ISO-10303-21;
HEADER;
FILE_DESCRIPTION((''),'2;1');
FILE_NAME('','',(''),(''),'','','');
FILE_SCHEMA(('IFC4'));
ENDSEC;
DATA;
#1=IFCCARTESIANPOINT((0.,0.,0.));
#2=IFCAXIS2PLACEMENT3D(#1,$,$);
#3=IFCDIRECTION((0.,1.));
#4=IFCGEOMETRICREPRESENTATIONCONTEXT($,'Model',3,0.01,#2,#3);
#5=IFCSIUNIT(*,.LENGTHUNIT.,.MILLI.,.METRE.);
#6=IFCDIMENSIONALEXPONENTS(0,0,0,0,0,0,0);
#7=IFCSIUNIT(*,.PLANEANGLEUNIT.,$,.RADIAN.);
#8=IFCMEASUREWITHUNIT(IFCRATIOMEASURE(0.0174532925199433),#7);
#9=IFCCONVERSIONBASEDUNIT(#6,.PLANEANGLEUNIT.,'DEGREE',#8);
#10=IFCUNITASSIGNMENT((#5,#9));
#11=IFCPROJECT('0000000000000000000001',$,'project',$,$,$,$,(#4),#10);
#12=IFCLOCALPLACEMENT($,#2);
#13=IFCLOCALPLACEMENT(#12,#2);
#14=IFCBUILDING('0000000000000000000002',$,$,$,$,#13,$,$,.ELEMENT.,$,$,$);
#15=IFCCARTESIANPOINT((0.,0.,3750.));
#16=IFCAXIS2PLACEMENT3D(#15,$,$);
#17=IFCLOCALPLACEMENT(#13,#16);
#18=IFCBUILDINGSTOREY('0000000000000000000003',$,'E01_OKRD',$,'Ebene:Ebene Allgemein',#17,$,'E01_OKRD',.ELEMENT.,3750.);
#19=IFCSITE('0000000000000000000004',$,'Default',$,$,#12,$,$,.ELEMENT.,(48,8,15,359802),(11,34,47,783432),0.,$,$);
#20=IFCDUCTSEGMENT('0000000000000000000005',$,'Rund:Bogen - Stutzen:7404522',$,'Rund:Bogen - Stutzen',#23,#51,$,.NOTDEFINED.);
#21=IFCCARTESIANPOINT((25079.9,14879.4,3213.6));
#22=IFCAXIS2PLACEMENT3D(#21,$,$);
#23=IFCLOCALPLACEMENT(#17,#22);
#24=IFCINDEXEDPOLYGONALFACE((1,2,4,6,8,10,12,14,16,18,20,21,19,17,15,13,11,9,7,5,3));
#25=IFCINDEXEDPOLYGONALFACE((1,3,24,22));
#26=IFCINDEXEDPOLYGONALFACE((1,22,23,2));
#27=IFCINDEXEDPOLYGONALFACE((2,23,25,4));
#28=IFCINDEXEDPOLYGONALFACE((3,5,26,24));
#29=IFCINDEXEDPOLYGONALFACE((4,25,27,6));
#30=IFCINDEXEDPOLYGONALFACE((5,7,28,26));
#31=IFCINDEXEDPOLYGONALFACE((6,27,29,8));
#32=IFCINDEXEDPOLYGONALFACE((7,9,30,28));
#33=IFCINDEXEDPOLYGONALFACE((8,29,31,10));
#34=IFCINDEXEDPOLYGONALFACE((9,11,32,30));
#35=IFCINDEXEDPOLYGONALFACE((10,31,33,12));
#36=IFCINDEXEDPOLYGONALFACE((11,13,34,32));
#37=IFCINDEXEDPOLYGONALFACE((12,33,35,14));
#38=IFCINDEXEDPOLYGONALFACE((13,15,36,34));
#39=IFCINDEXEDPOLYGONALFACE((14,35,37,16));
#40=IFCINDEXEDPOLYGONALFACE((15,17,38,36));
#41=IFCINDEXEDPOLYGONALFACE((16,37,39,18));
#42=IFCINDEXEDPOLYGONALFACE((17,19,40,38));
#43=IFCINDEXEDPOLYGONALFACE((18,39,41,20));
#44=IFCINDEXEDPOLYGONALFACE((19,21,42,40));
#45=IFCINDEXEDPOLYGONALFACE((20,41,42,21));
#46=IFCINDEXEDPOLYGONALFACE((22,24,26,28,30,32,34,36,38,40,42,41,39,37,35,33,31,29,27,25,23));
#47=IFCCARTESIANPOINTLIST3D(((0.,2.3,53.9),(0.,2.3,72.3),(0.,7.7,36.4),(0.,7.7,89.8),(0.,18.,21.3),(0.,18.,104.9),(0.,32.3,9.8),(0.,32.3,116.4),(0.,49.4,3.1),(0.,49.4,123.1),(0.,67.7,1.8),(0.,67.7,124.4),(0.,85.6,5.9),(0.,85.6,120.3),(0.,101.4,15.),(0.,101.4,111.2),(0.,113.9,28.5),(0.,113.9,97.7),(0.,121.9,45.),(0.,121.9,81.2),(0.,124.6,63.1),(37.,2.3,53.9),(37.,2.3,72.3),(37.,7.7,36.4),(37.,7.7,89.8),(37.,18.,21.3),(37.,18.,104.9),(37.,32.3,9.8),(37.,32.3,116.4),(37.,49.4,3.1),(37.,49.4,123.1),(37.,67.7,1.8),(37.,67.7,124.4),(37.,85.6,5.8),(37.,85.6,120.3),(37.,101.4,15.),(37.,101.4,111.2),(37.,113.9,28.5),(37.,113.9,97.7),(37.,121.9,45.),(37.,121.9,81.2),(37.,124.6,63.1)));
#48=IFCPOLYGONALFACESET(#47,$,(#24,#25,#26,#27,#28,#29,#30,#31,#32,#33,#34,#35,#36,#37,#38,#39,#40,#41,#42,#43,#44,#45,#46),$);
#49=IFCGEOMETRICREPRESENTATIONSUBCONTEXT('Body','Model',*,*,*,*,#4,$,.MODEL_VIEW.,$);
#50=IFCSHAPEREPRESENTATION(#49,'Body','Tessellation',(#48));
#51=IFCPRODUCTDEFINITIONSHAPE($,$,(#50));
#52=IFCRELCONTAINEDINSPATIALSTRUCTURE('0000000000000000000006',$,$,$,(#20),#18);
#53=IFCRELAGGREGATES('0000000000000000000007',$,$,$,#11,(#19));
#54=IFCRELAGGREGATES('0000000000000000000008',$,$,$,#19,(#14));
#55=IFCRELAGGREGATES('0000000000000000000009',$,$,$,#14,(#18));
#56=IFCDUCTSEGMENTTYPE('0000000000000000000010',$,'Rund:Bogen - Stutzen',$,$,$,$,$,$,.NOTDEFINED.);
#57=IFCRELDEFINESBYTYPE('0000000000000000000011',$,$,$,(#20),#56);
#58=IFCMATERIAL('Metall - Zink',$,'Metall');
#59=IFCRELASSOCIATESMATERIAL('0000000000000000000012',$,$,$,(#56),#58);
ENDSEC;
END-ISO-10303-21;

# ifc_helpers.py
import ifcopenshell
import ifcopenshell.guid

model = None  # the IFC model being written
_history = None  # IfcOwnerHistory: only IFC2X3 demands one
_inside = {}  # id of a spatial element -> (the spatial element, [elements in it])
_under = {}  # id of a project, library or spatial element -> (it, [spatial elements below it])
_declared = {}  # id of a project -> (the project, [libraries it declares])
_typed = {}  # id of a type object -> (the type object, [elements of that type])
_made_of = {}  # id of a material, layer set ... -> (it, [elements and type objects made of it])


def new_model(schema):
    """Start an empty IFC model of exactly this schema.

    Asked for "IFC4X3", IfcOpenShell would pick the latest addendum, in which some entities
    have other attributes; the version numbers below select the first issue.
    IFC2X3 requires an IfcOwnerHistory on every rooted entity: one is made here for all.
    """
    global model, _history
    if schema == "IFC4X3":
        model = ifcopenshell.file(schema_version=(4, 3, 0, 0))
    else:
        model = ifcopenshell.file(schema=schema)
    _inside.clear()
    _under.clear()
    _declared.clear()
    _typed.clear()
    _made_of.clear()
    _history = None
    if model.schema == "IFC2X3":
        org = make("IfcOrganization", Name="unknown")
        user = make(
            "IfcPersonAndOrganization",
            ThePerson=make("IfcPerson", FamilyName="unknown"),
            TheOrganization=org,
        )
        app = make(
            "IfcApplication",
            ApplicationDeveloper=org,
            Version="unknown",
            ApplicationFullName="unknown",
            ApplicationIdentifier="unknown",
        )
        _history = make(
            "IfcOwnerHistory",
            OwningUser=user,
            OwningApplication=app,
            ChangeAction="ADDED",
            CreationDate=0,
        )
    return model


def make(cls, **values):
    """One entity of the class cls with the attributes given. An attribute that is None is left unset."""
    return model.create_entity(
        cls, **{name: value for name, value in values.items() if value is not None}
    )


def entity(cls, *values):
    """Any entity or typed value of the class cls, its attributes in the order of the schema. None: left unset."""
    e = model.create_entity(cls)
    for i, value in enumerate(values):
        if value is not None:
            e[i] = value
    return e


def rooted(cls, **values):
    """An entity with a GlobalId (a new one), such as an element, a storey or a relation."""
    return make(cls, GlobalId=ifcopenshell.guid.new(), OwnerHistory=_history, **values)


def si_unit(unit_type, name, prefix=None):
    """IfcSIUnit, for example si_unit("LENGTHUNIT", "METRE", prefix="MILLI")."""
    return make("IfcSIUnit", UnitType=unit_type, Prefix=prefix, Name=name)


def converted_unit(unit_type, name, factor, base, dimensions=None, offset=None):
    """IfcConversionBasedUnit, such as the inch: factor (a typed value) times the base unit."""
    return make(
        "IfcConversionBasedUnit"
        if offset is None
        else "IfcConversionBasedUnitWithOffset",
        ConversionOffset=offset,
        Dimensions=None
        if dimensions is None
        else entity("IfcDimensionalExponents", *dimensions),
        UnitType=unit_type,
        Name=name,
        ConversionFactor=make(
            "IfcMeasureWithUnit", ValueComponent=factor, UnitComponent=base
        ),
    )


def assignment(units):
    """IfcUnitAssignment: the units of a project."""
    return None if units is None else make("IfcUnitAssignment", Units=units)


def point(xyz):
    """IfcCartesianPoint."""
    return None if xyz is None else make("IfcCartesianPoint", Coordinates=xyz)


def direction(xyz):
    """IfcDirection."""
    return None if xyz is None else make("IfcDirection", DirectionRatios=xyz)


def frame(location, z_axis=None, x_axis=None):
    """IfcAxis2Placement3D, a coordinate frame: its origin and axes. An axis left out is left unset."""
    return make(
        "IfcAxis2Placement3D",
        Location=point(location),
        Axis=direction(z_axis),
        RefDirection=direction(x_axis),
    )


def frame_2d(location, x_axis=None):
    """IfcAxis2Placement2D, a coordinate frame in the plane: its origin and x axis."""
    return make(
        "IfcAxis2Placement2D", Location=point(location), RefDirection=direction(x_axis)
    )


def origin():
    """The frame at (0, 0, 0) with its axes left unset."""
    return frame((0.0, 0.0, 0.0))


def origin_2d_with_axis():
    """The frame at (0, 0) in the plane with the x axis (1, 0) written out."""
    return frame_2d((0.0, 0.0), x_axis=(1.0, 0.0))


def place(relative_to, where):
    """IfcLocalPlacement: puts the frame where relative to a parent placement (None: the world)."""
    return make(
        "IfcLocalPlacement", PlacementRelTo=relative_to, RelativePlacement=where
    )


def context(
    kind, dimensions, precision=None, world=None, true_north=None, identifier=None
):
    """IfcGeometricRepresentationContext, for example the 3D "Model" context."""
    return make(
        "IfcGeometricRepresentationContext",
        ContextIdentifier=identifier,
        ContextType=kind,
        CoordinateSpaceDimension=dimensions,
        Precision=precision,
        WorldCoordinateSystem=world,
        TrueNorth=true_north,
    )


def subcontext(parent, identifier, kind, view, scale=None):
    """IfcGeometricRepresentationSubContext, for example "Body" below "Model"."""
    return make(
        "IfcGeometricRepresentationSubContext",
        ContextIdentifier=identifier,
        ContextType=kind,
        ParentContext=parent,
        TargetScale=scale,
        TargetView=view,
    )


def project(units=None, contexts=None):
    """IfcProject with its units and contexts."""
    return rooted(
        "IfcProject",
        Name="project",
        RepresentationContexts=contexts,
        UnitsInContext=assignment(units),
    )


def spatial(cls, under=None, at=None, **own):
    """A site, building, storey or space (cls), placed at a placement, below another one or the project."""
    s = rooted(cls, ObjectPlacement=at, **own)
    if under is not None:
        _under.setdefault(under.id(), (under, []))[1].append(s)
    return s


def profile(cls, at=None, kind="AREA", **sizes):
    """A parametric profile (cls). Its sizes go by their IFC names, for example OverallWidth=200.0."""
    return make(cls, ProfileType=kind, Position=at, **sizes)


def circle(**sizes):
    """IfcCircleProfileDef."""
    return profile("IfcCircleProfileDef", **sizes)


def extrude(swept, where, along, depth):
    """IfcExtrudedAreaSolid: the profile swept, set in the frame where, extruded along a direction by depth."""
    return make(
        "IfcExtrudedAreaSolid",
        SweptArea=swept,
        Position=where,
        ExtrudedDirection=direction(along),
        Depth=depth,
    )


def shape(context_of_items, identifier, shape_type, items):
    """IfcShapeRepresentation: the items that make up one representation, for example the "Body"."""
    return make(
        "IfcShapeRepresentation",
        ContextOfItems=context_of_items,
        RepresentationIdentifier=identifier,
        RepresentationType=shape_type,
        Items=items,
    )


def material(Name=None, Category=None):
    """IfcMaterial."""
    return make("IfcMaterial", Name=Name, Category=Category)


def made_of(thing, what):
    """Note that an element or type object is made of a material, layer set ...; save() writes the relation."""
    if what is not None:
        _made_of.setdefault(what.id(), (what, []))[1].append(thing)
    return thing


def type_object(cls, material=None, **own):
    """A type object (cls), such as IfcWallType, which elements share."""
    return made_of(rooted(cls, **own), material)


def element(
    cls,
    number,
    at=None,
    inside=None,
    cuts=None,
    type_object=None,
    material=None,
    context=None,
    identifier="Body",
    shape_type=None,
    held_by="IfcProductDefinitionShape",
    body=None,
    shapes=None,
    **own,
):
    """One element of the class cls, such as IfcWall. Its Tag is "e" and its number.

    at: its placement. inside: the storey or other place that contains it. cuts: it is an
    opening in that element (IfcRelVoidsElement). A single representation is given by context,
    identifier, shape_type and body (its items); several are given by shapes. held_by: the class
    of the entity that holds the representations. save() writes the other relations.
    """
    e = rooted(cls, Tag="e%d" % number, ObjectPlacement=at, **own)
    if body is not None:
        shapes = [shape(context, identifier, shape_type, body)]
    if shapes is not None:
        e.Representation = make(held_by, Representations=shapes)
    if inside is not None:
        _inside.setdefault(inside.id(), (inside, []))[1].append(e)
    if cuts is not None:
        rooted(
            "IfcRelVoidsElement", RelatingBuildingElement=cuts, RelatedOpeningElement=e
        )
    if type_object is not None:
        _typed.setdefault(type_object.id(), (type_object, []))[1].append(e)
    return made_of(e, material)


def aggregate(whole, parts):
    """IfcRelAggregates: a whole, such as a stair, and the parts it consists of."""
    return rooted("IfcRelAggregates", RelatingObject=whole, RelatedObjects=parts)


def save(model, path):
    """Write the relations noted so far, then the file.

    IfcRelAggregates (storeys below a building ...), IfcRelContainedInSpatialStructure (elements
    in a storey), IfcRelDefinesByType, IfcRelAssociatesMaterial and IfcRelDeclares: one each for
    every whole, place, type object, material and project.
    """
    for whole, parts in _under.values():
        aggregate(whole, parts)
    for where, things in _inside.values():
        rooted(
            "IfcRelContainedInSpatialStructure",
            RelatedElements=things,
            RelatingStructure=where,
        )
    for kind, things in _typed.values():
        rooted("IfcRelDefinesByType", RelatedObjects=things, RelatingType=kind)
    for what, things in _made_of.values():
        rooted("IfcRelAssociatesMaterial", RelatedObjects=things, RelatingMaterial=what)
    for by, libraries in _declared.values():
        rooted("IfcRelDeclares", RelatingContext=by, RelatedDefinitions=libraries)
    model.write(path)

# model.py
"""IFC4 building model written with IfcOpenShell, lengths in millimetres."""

from ifc_helpers import new_model, entity, si_unit, converted_unit, direction, frame, origin, origin_2d_with_axis, place, context, subcontext, project, spatial, circle, extrude, material, type_object, element, save


model = new_model("IFC4")

# Units and contexts
model_context = context("Model", 3, precision=0.01, world=origin(), true_north=direction((0.0, 1.0)))
body_context = subcontext(model_context, "Body", "Model", "MODEL_VIEW")
ifc_project = project(units=[si_unit("LENGTHUNIT", "METRE", prefix="MILLI"), converted_unit("PLANEANGLEUNIT", "DEGREE", entity("IfcRatioMeasure", 0.0174532925199433), si_unit("PLANEANGLEUNIT", "RADIAN"), dimensions=[0, 0, 0, 0, 0, 0, 0])], contexts=[model_context])

# Site, building, storey
site_placement = place(None, origin())
site = spatial("IfcSite", under=ifc_project, at=site_placement, Name="Default", CompositionType="ELEMENT", RefLatitude=(48, 8, 15, 359802), RefLongitude=(11, 34, 47, 783432), RefElevation=0.0)
building_placement = place(site_placement, origin())
building = spatial("IfcBuilding", under=site, at=building_placement, CompositionType="ELEMENT")
storey_placement = place(building_placement, frame((0.0, 0.0, 3750.0)))
storey = spatial("IfcBuildingStorey", under=building, at=storey_placement, Name="E01_OKRD", ObjectType="Ebene:Ebene Allgemein", LongName="E01_OKRD", CompositionType="ELEMENT", Elevation=3750.0)

# Shared definitions
ifc_material_1 = material(Name="Metall - Zink", Category="Metall")

# Duct segment
duct_segment_type_1 = type_object("IfcDuctSegmentType", Name="Rund:Bogen - Stutzen", PredefinedType="NOTDEFINED", material=ifc_material_1)
duct_segment_1_placement = place(storey_placement, frame((25079.9, 14879.4, 3213.6)))
element("IfcDuctSegment", 1, at=duct_segment_1_placement, inside=storey, type_object=duct_segment_type_1, Name="Rund:Bogen - Stutzen:7404522", ObjectType="Rund:Bogen - Stutzen", PredefinedType="NOTDEFINED", context=body_context, shape_type="SweptSolid", body=[
    extrude(circle(Radius=61.5, at=origin_2d_with_axis()), frame((37.0, 63.1, 63.1), z_axis=(-1.0, 0.0, 0.000116), x_axis=(0.0, 1.0, 0.0)), (0.0, 0.0, 1.0), 37.0),
])

save(model, "model.ifc")
